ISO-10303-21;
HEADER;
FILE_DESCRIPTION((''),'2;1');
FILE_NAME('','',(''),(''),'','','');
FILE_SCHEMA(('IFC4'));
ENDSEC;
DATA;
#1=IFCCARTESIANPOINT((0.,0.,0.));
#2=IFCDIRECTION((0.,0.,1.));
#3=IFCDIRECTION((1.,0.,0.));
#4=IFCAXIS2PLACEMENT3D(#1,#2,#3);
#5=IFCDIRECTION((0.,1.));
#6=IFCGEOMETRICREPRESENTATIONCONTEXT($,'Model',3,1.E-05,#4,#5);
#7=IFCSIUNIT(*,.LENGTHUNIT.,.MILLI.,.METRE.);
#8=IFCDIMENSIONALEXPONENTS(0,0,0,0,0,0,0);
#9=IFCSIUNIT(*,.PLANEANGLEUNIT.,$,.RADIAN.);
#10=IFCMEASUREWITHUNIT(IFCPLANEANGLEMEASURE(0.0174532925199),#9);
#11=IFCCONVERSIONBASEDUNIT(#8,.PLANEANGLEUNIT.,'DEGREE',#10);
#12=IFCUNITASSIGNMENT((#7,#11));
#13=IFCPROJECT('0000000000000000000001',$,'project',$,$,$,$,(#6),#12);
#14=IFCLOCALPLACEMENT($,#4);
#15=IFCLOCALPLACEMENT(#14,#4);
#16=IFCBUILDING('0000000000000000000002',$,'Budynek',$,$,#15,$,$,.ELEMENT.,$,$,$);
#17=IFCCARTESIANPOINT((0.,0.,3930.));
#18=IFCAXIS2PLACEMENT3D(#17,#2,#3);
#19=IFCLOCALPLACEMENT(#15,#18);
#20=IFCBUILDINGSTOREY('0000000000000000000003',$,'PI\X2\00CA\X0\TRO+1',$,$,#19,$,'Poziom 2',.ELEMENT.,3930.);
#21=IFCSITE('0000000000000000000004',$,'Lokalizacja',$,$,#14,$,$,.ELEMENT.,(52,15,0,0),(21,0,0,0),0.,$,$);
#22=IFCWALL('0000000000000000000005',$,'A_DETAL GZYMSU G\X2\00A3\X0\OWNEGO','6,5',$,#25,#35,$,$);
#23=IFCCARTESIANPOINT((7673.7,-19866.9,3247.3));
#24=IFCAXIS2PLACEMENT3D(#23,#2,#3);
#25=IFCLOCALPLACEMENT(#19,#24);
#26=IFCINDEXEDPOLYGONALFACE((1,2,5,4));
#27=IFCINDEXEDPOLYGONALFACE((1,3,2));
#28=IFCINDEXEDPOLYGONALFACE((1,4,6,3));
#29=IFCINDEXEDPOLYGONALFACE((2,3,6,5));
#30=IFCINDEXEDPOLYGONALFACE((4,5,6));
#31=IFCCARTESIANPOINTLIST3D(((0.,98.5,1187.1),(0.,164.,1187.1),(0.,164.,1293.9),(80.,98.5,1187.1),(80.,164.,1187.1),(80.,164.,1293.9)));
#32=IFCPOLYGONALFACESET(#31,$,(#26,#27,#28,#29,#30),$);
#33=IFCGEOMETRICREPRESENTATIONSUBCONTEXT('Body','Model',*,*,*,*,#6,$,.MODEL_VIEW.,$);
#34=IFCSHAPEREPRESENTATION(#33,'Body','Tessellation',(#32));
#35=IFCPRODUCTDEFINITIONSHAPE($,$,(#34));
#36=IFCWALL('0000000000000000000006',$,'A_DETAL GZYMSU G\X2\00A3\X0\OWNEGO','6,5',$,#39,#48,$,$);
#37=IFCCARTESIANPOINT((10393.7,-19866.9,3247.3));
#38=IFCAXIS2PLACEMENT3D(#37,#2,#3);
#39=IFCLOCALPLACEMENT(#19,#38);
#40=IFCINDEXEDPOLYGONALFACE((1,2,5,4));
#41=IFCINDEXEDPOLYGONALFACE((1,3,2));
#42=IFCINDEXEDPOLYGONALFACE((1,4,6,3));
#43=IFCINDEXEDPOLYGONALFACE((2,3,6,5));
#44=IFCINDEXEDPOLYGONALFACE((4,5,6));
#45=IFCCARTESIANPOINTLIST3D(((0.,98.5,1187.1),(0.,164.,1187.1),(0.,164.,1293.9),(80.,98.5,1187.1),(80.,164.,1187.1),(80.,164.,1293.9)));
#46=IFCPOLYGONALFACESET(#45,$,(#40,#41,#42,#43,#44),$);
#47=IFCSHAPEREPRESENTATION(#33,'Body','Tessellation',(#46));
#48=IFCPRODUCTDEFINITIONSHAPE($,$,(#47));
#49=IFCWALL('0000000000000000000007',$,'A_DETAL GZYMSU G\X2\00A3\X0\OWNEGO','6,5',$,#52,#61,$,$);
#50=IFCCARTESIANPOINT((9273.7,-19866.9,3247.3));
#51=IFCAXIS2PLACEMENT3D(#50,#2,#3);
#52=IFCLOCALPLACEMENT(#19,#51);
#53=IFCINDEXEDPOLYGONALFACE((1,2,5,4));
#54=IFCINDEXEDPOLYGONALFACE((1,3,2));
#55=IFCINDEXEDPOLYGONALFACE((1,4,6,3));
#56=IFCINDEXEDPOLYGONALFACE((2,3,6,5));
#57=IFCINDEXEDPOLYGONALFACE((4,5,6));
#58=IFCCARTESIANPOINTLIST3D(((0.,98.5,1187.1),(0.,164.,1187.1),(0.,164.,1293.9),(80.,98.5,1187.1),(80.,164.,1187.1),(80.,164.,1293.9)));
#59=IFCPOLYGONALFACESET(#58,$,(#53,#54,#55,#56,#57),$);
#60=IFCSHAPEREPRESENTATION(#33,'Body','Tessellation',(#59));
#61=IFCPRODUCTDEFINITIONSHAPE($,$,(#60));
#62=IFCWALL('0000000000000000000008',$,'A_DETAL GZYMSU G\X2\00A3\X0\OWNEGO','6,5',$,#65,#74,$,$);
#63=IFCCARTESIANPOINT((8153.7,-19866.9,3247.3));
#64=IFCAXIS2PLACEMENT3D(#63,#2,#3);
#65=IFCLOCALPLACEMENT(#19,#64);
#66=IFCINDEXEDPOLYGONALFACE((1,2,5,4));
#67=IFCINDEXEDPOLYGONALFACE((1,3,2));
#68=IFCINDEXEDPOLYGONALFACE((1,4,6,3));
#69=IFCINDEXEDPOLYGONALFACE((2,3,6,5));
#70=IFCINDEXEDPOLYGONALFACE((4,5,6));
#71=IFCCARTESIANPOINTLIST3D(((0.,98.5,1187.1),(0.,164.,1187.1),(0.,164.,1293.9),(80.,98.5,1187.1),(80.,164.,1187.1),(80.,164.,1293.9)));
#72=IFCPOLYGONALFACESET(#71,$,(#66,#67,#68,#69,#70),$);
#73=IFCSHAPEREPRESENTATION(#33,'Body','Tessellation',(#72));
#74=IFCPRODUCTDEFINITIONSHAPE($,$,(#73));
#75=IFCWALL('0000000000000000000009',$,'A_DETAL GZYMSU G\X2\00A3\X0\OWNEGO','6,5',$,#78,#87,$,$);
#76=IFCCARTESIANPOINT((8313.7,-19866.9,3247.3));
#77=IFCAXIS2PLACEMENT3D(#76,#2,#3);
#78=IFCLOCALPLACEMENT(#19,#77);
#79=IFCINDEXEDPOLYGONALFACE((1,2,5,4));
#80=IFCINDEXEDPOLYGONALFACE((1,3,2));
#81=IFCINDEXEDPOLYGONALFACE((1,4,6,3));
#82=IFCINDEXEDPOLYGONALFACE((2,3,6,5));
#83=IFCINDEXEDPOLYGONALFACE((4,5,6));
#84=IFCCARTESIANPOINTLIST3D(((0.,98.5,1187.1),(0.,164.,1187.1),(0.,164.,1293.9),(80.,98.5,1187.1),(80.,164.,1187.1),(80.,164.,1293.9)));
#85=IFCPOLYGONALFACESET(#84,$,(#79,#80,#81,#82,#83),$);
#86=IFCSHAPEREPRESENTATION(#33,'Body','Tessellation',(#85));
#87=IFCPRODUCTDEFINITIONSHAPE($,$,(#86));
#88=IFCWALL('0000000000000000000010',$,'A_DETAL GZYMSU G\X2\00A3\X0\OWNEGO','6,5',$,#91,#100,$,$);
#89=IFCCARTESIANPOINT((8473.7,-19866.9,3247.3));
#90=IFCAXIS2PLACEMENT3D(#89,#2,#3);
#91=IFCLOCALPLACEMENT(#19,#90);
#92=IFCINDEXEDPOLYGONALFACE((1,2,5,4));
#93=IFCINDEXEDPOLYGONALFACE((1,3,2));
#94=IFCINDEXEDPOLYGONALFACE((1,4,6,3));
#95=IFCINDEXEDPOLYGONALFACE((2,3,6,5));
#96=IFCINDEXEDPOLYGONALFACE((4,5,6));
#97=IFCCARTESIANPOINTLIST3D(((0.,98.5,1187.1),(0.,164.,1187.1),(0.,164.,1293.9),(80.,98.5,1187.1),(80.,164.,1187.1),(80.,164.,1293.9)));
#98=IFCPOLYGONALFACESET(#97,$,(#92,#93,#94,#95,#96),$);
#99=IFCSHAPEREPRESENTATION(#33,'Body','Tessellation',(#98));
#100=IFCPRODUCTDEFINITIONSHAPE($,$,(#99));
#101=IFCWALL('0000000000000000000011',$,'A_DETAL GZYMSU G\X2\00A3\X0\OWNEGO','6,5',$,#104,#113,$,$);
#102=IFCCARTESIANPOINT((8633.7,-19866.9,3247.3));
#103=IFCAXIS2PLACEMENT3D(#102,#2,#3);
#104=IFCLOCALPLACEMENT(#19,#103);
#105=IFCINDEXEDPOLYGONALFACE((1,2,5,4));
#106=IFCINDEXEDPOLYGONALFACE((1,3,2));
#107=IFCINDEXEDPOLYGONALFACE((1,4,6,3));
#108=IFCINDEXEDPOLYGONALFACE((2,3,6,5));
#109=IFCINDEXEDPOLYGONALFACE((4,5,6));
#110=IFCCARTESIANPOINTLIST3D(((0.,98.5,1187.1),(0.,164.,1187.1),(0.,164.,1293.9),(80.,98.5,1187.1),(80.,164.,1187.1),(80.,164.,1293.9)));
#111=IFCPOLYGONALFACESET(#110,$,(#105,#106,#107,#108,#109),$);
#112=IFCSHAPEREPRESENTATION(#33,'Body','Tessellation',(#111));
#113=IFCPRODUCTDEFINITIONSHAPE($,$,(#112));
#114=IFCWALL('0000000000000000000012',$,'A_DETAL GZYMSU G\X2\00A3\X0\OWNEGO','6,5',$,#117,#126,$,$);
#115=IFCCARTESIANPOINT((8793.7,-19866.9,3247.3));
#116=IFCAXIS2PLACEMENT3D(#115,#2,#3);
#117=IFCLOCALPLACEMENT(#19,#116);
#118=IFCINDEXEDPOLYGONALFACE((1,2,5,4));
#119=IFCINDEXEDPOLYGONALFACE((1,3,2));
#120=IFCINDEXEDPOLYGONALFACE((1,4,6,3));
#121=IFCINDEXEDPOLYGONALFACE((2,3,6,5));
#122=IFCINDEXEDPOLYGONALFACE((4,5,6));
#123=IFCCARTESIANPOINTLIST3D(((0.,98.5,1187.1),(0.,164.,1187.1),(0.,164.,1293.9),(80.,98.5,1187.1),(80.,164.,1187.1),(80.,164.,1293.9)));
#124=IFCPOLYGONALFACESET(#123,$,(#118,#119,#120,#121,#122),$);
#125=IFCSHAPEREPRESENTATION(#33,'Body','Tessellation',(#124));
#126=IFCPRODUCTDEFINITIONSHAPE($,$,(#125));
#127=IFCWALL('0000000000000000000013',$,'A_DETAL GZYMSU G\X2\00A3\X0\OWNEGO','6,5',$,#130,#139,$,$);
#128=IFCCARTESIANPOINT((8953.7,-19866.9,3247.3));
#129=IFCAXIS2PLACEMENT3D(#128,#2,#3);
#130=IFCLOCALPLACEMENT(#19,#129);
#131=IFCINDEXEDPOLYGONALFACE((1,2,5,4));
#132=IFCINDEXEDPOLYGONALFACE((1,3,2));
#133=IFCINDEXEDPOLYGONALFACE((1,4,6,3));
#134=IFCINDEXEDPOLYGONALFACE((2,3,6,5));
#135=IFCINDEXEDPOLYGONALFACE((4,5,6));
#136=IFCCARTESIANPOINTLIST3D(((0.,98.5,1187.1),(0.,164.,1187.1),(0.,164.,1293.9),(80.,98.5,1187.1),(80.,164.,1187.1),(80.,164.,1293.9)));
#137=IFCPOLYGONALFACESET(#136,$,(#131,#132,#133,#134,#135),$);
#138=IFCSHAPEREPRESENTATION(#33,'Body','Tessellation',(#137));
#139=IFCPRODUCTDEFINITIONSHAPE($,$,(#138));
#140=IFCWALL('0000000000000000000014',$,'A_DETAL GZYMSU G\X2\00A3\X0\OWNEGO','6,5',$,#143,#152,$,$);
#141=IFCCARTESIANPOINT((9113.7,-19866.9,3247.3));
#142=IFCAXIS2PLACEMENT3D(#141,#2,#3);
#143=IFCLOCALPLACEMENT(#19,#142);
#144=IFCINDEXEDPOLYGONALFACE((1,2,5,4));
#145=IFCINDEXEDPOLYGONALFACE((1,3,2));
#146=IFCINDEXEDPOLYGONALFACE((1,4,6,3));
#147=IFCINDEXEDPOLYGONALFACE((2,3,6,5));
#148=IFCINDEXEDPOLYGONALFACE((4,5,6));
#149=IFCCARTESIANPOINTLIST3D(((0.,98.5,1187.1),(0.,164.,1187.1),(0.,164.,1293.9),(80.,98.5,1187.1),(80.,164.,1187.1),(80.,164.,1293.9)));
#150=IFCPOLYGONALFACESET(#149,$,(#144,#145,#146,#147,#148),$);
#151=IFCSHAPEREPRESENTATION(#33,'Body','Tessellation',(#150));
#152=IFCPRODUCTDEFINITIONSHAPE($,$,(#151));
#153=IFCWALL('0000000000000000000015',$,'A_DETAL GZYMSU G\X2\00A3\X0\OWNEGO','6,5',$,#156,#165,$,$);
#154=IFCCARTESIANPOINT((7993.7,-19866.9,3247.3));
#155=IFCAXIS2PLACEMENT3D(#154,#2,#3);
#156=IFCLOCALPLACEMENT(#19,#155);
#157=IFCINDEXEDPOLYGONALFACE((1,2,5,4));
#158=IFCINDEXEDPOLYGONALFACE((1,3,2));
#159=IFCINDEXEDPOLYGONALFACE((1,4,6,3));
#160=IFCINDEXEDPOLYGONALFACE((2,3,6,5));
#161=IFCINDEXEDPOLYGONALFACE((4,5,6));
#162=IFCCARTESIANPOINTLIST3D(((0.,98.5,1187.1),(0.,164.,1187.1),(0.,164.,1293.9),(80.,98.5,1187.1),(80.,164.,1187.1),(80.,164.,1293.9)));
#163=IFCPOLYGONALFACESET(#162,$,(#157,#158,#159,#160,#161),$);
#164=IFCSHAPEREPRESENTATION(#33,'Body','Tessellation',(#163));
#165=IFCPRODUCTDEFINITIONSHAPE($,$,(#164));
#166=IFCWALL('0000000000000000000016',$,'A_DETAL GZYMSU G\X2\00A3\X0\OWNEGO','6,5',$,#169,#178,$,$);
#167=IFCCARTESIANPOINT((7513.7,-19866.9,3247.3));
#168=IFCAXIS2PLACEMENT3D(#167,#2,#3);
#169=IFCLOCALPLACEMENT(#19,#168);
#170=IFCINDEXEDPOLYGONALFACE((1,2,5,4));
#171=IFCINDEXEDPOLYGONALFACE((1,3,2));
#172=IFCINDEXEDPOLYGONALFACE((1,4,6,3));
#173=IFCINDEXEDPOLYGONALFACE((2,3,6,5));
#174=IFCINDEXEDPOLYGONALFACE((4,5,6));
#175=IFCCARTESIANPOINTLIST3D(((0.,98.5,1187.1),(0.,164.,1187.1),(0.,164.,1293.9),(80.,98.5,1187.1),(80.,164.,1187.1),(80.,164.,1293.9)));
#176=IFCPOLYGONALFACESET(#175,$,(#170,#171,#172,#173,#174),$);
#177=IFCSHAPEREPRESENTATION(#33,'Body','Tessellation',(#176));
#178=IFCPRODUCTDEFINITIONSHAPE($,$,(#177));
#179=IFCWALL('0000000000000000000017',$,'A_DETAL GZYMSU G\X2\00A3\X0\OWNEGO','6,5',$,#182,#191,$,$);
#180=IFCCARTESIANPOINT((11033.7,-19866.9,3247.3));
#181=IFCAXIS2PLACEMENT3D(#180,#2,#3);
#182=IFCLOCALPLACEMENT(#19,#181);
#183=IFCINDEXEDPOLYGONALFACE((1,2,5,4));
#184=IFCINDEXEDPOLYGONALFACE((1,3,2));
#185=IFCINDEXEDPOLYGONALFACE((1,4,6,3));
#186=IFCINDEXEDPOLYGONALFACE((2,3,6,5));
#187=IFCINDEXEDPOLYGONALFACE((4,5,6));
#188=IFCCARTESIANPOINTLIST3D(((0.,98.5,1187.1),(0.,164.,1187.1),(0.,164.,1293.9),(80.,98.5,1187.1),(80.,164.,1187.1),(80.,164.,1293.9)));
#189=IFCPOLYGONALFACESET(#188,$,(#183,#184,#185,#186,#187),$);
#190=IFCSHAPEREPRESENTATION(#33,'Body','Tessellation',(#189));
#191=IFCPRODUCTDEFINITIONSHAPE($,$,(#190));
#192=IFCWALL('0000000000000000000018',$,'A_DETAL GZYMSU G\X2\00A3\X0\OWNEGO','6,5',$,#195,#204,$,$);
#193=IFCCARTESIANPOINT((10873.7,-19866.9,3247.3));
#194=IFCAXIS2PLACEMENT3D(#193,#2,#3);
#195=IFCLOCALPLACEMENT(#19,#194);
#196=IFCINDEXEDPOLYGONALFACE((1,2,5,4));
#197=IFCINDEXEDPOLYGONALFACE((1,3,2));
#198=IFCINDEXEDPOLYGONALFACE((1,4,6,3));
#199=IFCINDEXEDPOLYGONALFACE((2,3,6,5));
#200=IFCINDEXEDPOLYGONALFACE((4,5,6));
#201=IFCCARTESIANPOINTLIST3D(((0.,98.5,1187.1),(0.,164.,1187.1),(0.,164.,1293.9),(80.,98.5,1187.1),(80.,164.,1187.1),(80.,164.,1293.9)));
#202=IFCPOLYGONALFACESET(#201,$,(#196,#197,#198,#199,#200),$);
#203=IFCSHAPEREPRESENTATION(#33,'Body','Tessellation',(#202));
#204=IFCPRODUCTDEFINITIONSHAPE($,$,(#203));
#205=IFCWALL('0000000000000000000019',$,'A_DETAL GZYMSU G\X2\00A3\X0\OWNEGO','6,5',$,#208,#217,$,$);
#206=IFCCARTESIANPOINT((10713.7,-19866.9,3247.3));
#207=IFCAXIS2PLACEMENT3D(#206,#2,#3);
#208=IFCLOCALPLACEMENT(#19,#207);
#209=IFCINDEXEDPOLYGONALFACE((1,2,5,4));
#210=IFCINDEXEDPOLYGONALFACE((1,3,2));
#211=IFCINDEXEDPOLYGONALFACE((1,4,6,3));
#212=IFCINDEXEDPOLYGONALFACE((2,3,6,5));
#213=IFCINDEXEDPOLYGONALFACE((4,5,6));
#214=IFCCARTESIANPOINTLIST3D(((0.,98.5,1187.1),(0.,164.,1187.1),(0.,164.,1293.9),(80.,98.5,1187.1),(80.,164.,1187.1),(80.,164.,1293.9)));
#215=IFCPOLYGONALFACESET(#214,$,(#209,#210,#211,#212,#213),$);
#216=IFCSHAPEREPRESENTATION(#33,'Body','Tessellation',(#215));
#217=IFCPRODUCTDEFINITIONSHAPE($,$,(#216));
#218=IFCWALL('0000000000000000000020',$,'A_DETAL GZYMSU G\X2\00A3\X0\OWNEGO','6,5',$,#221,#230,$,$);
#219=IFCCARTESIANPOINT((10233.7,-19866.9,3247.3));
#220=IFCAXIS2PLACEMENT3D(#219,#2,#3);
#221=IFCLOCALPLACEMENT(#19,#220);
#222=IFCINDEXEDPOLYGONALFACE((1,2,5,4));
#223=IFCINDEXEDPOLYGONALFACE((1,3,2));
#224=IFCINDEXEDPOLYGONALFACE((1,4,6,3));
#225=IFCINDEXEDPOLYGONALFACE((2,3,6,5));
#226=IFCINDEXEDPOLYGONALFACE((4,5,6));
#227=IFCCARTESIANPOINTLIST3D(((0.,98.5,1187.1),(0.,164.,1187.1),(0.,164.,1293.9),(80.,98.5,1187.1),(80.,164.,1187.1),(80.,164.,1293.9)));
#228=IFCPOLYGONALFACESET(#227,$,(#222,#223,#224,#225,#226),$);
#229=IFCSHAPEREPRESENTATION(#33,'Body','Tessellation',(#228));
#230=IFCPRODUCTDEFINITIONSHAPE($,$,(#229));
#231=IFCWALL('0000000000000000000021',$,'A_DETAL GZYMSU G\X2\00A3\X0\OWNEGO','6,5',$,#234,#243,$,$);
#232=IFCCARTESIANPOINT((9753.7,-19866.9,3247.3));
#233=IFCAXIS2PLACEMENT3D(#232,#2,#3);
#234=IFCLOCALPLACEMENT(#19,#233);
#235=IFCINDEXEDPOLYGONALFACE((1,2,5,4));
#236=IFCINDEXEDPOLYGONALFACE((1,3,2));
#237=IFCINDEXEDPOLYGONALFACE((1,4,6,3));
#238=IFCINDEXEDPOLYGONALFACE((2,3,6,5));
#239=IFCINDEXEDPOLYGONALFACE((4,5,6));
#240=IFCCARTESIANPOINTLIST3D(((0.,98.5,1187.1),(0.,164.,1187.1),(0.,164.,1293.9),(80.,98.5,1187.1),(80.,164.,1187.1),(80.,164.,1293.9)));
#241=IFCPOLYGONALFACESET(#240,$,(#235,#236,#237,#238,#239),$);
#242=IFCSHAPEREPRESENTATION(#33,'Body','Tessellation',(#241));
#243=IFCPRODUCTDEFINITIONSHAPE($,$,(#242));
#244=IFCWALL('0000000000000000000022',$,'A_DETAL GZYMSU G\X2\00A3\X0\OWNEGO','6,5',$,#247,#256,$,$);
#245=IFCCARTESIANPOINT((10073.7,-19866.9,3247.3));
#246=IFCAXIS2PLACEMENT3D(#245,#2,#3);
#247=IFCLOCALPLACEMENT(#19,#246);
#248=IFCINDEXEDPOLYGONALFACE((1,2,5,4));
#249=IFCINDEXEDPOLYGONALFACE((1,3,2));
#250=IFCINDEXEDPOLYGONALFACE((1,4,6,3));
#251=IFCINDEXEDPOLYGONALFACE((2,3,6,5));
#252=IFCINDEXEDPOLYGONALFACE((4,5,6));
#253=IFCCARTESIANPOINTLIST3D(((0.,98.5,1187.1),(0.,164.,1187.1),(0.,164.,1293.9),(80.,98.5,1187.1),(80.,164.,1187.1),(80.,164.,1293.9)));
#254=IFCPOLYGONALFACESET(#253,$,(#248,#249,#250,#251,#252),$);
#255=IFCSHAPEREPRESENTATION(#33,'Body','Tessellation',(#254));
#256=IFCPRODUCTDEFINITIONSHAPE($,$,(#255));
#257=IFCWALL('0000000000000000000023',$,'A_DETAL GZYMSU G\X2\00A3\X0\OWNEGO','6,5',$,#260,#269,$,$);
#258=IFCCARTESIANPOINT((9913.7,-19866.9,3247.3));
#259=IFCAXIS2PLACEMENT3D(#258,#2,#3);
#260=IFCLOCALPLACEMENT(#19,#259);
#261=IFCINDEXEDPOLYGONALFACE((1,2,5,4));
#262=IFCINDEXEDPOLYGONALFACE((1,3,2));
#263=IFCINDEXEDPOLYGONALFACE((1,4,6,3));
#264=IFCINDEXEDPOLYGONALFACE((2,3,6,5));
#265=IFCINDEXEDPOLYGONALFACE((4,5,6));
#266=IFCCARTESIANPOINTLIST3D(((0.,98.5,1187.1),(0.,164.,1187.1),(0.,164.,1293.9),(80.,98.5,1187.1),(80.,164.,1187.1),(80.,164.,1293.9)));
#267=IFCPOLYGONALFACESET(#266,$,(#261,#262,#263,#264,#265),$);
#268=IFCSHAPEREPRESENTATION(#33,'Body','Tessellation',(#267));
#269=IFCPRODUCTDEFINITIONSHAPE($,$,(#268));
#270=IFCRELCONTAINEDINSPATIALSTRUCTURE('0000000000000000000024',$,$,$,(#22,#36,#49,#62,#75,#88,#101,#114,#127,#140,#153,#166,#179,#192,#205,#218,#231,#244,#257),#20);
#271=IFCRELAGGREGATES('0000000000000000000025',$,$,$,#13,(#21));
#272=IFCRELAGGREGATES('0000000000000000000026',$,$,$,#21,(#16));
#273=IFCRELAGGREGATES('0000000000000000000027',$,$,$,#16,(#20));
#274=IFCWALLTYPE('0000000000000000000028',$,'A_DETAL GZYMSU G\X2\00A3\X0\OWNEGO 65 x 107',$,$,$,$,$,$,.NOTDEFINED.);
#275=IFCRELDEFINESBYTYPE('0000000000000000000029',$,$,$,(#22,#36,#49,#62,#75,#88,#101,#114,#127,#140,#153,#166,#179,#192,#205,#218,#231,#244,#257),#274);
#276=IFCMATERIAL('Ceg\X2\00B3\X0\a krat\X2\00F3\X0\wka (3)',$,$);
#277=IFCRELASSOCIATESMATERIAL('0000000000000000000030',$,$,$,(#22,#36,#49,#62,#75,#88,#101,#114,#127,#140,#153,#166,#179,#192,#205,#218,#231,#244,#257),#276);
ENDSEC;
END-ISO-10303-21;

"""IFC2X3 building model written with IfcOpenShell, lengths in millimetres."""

from ifc_helpers import new_model, entity, si_unit, converted_unit, direction, frame, origin_with_axes, place, context, subcontext, project, spatial, polyline, outline, extrude, material, type_object, element, save


model = new_model("IFC2X3")

# Units and contexts
model_context = context("Model", 3, precision=1e-05, world=origin_with_axes(), true_north=direction((0.0, 1.0)))
body_context = subcontext(model_context, "Body", "Model", "MODEL_VIEW")
ifc_project = project(units=[si_unit("LENGTHUNIT", "METRE", prefix="MILLI"), converted_unit("PLANEANGLEUNIT", "DEGREE", entity("IfcPlaneAngleMeasure", 0.0174532925199), si_unit("PLANEANGLEUNIT", "RADIAN"), dimensions=[0, 0, 0, 0, 0, 0, 0])], contexts=[model_context])

# Site, building, storey
site_placement = place(None, origin_with_axes())
site = spatial("IfcSite", under=ifc_project, at=site_placement, Name="Lokalizacja", CompositionType="ELEMENT", RefLatitude=(52, 15, 0, 0), RefLongitude=(21, 0, 0, 0), RefElevation=0.0)
building_placement = place(site_placement, origin_with_axes())
building = spatial("IfcBuilding", under=site, at=building_placement, Name="Budynek", CompositionType="ELEMENT")
storey_placement = place(building_placement, frame((0.0, 0.0, 3930.0), z_axis=(0.0, 0.0, 1.0), x_axis=(1.0, 0.0, 0.0)))
storey = spatial("IfcBuildingStorey", under=building, at=storey_placement, Name="PIÊTRO+1", LongName="Poziom 2", CompositionType="ELEMENT", Elevation=3930.0)

# Walls
ifc_material_1 = material(Name="Ceg³a kratówka (3)")
wall_type = type_object("IfcWallType", Name="A_DETAL GZYMSU G£OWNEGO 65 x 107", PredefinedType="NOTDEFINED")
for number, where, z_axis, x_axis, name in (
    (1, (7673.7, -19866.9, 3247.3), (0.0, 0.0, 1.0), (1.0, 0.0, 0.0), "A_DETAL GZYMSU G£OWNEGO"),
    (2, (10393.7, -19866.9, 3247.3), (0.0, 0.0, 1.0), (1.0, 0.0, 0.0), "A_DETAL GZYMSU G£OWNEGO"),
    (3, (9273.7, -19866.9, 3247.3), (0.0, 0.0, 1.0), (1.0, 0.0, 0.0), "A_DETAL GZYMSU G£OWNEGO"),
    (4, (8153.7, -19866.9, 3247.3), (0.0, 0.0, 1.0), (1.0, 0.0, 0.0), "A_DETAL GZYMSU G£OWNEGO"),
    (5, (8313.7, -19866.9, 3247.3), (0.0, 0.0, 1.0), (1.0, 0.0, 0.0), "A_DETAL GZYMSU G£OWNEGO"),
    (6, (8473.7, -19866.9, 3247.3), (0.0, 0.0, 1.0), (1.0, 0.0, 0.0), "A_DETAL GZYMSU G£OWNEGO"),
    (7, (8633.7, -19866.9, 3247.3), (0.0, 0.0, 1.0), (1.0, 0.0, 0.0), "A_DETAL GZYMSU G£OWNEGO"),
    (8, (8793.7, -19866.9, 3247.3), (0.0, 0.0, 1.0), (1.0, 0.0, 0.0), "A_DETAL GZYMSU G£OWNEGO"),
    (9, (8953.7, -19866.9, 3247.3), (0.0, 0.0, 1.0), (1.0, 0.0, 0.0), "A_DETAL GZYMSU G£OWNEGO"),
    (10, (9113.7, -19866.9, 3247.3), (0.0, 0.0, 1.0), (1.0, 0.0, 0.0), "A_DETAL GZYMSU G£OWNEGO"),
    (11, (7993.7, -19866.9, 3247.3), (0.0, 0.0, 1.0), (1.0, 0.0, 0.0), "A_DETAL GZYMSU G£OWNEGO"),
    (12, (7513.7, -19866.9, 3247.3), (0.0, 0.0, 1.0), (1.0, 0.0, 0.0), "A_DETAL GZYMSU G£OWNEGO"),
    (13, (11033.7, -19866.9, 3247.3), (0.0, 0.0, 1.0), (1.0, 0.0, 0.0), "A_DETAL GZYMSU G£OWNEGO"),
    (14, (10873.7, -19866.9, 3247.3), (0.0, 0.0, 1.0), (1.0, 0.0, 0.0), "A_DETAL GZYMSU G£OWNEGO"),
    (15, (10713.7, -19866.9, 3247.3), (0.0, 0.0, 1.0), (1.0, 0.0, 0.0), "A_DETAL GZYMSU G£OWNEGO"),
    (16, (10233.7, -19866.9, 3247.3), (0.0, 0.0, 1.0), (1.0, 0.0, 0.0), "A_DETAL GZYMSU G£OWNEGO"),
    (17, (9753.7, -19866.9, 3247.3), (0.0, 0.0, 1.0), (1.0, 0.0, 0.0), "A_DETAL GZYMSU G£OWNEGO"),
    (18, (10073.7, -19866.9, 3247.3), (0.0, 0.0, 1.0), (1.0, 0.0, 0.0), "A_DETAL GZYMSU G£OWNEGO"),
    (19, (9913.7, -19866.9, 3247.3), (0.0, 0.0, 1.0), (1.0, 0.0, 0.0), "A_DETAL GZYMSU G£OWNEGO"),
):
    element("IfcWall", number, at=place(storey_placement, frame(where, z_axis=z_axis, x_axis=x_axis)), inside=storey, type_object=wall_type, material=ifc_material_1, Name=name, Description="6,5", context=body_context, shape_type="SweptSolid", body=[
        extrude(outline(polyline([(-164.0, 1293.9), (-164.0, 1187.1), (-98.5, 1187.1), (-164.0, 1293.9)])), frame((0.0, 0.0, 0.0), z_axis=(-1.0, 0.0, 0.0), x_axis=(0.0, -1.0, 0.0)), (0.0, 0.0, -1.0), 80.0),
    ])

save(model, "model.ifc")
